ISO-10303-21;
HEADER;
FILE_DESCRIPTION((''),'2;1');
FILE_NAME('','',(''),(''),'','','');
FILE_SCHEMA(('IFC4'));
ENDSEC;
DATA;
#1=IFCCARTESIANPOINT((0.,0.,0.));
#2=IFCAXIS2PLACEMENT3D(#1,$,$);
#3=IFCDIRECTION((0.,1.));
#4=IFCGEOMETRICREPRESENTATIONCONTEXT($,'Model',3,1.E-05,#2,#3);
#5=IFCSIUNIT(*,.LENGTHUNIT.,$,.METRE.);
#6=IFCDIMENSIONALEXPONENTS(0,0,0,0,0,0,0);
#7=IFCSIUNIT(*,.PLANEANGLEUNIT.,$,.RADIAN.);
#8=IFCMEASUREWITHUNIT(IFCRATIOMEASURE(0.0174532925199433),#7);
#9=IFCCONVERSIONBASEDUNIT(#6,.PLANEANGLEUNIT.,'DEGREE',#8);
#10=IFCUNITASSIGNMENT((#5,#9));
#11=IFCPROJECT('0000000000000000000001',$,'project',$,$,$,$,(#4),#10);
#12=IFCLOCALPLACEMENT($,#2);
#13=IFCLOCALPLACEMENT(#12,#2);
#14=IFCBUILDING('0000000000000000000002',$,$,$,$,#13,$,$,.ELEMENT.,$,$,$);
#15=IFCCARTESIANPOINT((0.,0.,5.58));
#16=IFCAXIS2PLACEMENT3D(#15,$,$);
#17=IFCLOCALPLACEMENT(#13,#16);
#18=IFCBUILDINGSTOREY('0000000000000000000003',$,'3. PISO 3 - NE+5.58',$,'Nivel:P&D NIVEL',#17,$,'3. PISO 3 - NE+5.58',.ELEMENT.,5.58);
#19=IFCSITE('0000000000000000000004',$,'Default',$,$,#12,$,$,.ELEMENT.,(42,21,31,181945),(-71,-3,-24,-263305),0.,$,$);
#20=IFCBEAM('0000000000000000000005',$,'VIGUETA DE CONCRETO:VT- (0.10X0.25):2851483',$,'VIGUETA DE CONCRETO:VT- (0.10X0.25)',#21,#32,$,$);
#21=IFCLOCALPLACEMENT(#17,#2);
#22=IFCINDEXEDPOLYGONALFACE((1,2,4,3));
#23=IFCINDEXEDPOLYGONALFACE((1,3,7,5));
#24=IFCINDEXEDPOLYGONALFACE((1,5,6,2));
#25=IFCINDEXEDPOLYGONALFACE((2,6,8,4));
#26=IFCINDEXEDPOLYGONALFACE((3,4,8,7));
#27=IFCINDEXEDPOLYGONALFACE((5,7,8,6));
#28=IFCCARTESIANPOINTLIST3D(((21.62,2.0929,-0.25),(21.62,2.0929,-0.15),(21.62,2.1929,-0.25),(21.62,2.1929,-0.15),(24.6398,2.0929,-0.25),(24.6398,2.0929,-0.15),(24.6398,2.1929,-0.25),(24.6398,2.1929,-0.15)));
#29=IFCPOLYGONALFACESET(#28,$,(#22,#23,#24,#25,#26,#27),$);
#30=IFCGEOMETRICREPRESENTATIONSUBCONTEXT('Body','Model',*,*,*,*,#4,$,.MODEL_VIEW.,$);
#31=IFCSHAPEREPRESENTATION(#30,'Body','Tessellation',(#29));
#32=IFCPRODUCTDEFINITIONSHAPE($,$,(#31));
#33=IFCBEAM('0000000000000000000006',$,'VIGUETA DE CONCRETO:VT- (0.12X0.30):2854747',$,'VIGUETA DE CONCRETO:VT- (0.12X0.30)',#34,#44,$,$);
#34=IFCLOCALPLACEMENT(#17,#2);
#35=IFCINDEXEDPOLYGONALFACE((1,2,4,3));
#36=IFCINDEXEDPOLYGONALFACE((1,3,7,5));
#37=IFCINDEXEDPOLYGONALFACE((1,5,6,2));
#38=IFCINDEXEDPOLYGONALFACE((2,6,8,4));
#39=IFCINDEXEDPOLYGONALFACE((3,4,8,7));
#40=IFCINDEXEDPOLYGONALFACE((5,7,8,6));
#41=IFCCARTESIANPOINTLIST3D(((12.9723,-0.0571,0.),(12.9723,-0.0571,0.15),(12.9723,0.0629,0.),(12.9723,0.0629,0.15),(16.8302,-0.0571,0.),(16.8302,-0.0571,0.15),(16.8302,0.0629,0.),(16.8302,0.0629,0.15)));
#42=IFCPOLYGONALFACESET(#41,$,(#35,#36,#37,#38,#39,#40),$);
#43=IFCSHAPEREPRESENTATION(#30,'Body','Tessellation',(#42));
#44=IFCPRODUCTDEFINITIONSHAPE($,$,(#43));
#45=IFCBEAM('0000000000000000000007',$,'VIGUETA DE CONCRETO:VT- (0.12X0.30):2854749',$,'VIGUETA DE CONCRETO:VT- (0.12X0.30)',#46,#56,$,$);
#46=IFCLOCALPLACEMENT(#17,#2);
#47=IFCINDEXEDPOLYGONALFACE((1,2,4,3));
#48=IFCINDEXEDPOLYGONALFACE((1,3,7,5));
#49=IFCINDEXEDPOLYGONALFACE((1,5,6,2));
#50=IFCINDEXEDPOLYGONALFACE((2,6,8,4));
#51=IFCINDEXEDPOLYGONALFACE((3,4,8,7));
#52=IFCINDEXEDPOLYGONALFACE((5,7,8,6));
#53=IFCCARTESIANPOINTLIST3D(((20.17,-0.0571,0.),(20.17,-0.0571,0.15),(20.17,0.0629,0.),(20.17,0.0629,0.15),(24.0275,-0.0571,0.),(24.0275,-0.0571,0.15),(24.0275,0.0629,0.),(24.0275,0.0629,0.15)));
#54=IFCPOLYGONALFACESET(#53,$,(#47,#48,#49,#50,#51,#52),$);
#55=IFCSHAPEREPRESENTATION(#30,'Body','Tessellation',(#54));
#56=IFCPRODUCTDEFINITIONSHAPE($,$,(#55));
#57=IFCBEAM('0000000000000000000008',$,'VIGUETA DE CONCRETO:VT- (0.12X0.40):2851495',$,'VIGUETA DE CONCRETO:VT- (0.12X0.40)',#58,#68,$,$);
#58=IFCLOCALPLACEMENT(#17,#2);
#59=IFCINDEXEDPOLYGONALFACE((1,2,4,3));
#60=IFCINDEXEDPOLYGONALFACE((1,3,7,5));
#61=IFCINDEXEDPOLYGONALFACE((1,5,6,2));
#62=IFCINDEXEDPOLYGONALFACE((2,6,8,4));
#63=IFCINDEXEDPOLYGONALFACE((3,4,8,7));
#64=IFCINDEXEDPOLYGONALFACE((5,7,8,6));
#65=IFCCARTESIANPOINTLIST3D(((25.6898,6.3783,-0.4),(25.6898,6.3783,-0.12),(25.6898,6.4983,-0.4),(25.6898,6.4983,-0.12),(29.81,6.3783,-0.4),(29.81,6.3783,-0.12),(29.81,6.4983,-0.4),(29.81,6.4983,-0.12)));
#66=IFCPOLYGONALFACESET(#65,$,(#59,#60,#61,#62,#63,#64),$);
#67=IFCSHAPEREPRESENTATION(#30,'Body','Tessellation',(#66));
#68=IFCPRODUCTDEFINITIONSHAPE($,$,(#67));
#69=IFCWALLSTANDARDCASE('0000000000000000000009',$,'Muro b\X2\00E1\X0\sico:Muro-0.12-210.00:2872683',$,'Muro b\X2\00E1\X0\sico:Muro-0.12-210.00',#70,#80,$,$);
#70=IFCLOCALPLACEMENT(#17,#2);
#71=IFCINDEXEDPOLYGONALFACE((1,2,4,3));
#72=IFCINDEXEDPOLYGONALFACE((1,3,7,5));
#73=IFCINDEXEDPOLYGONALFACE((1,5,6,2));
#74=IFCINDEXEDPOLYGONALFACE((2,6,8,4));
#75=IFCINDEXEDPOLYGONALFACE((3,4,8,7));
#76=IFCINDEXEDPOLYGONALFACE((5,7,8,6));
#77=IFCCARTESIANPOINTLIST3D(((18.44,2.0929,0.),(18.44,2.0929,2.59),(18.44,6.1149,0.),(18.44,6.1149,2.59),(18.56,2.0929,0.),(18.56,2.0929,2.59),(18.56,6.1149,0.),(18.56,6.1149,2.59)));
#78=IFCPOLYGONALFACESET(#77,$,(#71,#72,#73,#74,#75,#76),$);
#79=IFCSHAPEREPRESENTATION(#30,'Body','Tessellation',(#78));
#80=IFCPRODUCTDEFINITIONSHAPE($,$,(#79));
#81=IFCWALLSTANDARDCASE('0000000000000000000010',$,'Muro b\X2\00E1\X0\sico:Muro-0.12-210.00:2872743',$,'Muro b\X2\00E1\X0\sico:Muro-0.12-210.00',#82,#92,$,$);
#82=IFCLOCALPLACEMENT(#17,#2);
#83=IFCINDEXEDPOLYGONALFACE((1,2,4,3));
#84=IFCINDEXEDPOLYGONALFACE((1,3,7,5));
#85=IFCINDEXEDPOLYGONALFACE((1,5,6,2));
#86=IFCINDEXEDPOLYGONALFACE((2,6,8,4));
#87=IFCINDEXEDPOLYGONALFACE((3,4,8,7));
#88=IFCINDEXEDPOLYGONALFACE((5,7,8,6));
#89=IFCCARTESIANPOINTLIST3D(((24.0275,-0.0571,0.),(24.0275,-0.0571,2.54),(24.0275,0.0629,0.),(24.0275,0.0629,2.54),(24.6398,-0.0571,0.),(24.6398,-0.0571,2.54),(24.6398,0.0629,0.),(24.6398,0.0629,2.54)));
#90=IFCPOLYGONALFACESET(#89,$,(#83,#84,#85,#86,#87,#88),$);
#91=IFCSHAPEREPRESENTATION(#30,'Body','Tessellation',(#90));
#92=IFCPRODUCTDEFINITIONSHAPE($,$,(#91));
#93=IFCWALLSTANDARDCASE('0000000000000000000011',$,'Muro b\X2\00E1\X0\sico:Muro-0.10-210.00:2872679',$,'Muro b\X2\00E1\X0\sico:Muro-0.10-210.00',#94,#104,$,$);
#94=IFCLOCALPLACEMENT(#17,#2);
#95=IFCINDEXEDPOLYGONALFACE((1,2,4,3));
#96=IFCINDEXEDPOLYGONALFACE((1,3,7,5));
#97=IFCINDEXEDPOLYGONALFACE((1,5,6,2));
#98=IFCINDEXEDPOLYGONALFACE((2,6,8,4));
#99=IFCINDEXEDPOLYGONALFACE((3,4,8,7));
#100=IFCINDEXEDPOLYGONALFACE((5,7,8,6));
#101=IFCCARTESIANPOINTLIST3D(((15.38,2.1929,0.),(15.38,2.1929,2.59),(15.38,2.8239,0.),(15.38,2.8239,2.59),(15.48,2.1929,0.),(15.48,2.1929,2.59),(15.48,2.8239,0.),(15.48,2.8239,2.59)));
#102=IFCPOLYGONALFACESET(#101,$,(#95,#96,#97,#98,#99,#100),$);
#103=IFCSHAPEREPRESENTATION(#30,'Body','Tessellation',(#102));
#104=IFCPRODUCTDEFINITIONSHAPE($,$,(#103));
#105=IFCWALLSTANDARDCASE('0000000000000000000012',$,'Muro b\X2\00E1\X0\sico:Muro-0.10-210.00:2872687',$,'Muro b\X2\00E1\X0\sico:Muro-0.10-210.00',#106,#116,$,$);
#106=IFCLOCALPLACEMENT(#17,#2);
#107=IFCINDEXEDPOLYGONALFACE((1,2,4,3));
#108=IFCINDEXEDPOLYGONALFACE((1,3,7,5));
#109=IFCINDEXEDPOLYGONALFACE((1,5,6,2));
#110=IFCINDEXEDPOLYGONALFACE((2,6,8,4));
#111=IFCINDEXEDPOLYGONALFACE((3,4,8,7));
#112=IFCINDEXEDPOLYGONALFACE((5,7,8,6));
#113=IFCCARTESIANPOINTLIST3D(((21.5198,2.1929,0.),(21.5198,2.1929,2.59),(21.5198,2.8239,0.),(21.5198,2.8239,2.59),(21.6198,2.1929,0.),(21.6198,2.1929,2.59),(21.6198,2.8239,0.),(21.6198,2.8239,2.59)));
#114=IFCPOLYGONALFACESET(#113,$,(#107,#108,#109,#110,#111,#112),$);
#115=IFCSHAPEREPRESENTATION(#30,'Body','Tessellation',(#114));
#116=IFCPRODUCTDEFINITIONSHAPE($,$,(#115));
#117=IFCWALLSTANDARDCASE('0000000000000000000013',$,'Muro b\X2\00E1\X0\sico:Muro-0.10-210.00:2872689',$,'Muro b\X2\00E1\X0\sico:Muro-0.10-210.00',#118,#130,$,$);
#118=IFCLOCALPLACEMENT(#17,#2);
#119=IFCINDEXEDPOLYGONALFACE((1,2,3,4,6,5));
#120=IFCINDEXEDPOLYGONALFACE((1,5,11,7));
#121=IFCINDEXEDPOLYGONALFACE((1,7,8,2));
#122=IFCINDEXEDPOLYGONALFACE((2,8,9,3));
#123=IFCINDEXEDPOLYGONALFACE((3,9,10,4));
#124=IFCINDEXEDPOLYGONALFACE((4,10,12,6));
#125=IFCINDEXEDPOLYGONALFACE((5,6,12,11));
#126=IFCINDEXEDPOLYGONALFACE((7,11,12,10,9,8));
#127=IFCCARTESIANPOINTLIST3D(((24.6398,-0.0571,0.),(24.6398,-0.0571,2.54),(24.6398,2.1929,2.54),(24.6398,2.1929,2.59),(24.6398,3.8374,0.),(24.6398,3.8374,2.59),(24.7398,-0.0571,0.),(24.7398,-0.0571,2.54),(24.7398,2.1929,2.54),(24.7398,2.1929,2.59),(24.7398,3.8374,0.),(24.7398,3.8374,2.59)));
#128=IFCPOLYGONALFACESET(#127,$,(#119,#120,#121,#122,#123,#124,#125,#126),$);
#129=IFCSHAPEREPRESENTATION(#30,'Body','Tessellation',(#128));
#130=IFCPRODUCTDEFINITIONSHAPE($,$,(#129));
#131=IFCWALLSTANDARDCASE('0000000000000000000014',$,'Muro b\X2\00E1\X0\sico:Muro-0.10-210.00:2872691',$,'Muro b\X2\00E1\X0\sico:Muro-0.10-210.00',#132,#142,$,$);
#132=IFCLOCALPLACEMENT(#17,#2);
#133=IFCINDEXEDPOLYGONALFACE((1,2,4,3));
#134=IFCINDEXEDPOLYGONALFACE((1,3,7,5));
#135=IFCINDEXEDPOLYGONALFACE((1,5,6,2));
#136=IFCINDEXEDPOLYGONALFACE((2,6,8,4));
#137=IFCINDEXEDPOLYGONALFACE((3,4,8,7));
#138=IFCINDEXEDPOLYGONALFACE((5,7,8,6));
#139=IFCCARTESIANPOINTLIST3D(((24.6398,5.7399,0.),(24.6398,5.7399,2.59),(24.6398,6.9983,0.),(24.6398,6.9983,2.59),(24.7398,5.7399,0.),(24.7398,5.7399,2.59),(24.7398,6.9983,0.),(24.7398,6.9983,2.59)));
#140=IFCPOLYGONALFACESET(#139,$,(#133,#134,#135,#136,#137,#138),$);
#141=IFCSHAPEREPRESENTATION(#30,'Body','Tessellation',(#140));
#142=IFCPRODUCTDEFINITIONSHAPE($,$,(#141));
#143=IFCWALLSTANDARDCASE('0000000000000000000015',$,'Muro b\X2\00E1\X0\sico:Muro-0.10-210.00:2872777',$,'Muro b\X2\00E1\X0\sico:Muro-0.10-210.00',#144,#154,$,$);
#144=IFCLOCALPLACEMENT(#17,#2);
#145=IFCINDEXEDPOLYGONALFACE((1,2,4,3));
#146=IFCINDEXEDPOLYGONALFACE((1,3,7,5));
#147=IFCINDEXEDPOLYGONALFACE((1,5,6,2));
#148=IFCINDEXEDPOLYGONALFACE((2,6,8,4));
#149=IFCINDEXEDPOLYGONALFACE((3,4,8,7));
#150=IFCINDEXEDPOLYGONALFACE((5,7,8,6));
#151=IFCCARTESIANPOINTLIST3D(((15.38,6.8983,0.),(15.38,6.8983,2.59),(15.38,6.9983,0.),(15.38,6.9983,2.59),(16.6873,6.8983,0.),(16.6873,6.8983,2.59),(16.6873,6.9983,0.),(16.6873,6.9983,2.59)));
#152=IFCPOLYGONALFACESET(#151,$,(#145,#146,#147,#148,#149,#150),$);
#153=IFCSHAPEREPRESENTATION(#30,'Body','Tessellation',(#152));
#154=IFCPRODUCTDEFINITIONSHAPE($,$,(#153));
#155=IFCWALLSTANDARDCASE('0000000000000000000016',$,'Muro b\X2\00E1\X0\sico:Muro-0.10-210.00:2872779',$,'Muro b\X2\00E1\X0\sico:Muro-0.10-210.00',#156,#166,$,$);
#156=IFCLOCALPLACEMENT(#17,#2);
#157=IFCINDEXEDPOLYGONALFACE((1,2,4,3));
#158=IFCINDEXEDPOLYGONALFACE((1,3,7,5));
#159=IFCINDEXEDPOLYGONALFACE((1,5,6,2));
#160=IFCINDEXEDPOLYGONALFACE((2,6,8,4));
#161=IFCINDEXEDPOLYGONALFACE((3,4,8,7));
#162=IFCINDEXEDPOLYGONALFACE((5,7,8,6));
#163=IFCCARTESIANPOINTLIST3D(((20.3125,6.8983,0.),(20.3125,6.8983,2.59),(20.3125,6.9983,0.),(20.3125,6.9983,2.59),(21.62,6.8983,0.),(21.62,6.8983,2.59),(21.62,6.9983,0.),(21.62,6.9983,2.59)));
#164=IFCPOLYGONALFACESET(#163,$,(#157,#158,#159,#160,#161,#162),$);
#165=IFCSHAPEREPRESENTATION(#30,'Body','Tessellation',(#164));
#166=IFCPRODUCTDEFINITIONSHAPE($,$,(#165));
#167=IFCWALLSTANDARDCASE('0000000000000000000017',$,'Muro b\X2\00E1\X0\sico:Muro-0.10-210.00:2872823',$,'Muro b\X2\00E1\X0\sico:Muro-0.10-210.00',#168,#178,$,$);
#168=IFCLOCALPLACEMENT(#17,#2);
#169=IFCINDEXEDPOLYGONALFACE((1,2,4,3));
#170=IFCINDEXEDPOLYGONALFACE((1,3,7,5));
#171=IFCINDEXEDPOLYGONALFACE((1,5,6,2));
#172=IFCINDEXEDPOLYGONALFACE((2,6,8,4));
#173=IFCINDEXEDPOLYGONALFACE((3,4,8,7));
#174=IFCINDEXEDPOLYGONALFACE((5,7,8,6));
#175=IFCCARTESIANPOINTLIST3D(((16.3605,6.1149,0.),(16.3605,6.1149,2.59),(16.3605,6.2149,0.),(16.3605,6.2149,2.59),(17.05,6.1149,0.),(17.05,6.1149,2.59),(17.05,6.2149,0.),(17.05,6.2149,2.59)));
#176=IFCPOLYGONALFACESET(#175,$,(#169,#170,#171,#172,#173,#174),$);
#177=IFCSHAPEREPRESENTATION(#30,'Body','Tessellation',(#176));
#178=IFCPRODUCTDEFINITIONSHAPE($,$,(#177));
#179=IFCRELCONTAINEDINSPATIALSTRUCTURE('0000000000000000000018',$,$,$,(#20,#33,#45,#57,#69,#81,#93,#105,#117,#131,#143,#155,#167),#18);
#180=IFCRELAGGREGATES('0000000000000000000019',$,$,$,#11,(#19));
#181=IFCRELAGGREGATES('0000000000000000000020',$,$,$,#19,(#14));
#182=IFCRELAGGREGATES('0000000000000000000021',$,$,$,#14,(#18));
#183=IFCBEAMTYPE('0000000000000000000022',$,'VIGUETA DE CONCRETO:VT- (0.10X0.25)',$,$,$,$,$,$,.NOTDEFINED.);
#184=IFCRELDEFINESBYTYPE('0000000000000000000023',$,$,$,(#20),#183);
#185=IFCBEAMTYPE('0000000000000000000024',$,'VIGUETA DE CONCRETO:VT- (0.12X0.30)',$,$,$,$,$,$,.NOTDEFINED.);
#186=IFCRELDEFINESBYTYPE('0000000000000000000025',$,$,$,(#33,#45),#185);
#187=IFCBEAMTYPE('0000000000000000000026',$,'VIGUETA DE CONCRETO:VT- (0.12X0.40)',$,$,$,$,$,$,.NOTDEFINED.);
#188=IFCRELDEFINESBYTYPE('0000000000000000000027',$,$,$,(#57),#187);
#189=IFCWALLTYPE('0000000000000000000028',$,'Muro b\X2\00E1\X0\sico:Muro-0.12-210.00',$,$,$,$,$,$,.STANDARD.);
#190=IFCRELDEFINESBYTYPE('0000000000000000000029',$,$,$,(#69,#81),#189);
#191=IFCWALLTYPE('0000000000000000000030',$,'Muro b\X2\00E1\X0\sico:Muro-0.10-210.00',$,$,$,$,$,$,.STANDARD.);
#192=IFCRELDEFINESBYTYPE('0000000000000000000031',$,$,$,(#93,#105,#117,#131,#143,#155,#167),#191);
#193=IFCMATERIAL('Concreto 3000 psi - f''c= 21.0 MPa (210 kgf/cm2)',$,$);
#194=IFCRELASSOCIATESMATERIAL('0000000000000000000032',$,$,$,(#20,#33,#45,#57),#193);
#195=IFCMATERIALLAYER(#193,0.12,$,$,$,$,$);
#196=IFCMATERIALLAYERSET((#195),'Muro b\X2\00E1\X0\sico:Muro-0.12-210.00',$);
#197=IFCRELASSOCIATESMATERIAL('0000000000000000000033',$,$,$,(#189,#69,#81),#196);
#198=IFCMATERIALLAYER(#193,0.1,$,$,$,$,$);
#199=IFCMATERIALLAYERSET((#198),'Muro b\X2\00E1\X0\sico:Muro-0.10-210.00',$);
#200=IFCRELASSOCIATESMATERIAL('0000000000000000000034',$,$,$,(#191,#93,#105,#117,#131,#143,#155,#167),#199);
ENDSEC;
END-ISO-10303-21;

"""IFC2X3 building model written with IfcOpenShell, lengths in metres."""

from ifc_helpers import new_model, entity, si_unit, converted_unit, direction, frame, frame_2d, origin, origin_2d_with_axis, place, context, subcontext, project, spatial, polyline, rectangle, extrude, clip, bounded_halfspace, material, layer, layer_set, layer_usage, type_object, element, save


model = new_model("IFC2X3")

# Units and contexts
model_context = context("Model", 3, precision=1e-05, world=origin(), true_north=direction((0.0, 1.0)))
body_context = subcontext(model_context, "Body", "Model", "MODEL_VIEW")
ifc_project = project(units=[si_unit("LENGTHUNIT", "METRE"), converted_unit("PLANEANGLEUNIT", "DEGREE", entity("IfcRatioMeasure", 0.0174532925199433), si_unit("PLANEANGLEUNIT", "RADIAN"), dimensions=[0, 0, 0, 0, 0, 0, 0])], contexts=[model_context])

# Site, building, storey
site_placement = place(None, origin())
site = spatial("IfcSite", under=ifc_project, at=site_placement, Name="Default", CompositionType="ELEMENT", RefLatitude=(42, 21, 31, 181945), RefLongitude=(-71, -3, -24, -263305), RefElevation=0.0)
building_placement = place(site_placement, origin())
building = spatial("IfcBuilding", under=site, at=building_placement, CompositionType="ELEMENT")
storey_placement = place(building_placement, frame((0.0, 0.0, 5.58)))
storey = spatial("IfcBuildingStorey", under=building, at=storey_placement, Name="3. PISO 3 - NE+5.58", ObjectType="Nivel:P&D NIVEL", LongName="3. PISO 3 - NE+5.58", CompositionType="ELEMENT", Elevation=5.58)

# Beams
ifc_material = material(Name="Concreto 3000 psi - f'c= 21.0 MPa (210 kgf/cm2)")
beam_type_1 = type_object("IfcBeamType", Name="VIGUETA DE CONCRETO:VT- (0.10X0.25)", PredefinedType="NOTDEFINED")
beam_1_placement = place(storey_placement, frame((24.6898, 2.1429, 0.0), z_axis=(0.0, 0.0, 1.0), x_axis=(-1.0, 0.0, 0.0)))
element("IfcBeam", 1, at=beam_1_placement, inside=storey, type_object=beam_type_1, material=ifc_material, Name="VIGUETA DE CONCRETO:VT- (0.10X0.25):2851483", ObjectType="VIGUETA DE CONCRETO:VT- (0.10X0.25)", context=body_context, shape_type="SweptSolid", body=[
    extrude(rectangle(XDim=0.1, YDim=0.1, at=origin_2d_with_axis()), frame((0.05, 0.0, -0.2), z_axis=(1.0, 0.0, 0.0), x_axis=(0.0, 0.0, -1.0)), (0.0, 0.0, 1.0), 3.0198),
])
beam_type_2 = type_object("IfcBeamType", Name="VIGUETA DE CONCRETO:VT- (0.12X0.30)", PredefinedType="NOTDEFINED")
beam_2_placement = place(storey_placement, frame((16.9052, 0.0029, 0.0), z_axis=(0.0, 0.0, 1.0), x_axis=(-1.0, 0.0, 0.0)))
element("IfcBeam", 2, at=beam_2_placement, inside=storey, type_object=beam_type_2, material=ifc_material, Name="VIGUETA DE CONCRETO:VT- (0.12X0.30):2854747", ObjectType="VIGUETA DE CONCRETO:VT- (0.12X0.30)", context=body_context, shape_type="SweptSolid", body=[
    extrude(rectangle(XDim=0.15, YDim=0.12, at=frame_2d((0.0, 0.0), x_axis=(1.0, 0.0))), frame((0.075, 0.0, 0.075), z_axis=(1.0, 0.0, 0.0), x_axis=(0.0, 0.0, -1.0)), (0.0, 0.0, 1.0), 3.8579),
])
beam_3_placement = place(storey_placement, frame((20.095, 0.0029, 0.0)))
element("IfcBeam", 3, at=beam_3_placement, inside=storey, type_object=beam_type_2, material=ifc_material, Name="VIGUETA DE CONCRETO:VT- (0.12X0.30):2854749", ObjectType="VIGUETA DE CONCRETO:VT- (0.12X0.30)", context=body_context, shape_type="SweptSolid", body=[
    extrude(rectangle(XDim=0.15, YDim=0.12, at=frame_2d((0.0, 0.0), x_axis=(1.0, 0.0))), frame((0.075, 0.0, 0.075), z_axis=(1.0, 0.0, 0.0), x_axis=(0.0, 0.0, -1.0)), (0.0, 0.0, 1.0), 3.8575),
])
beam_type_3 = type_object("IfcBeamType", Name="VIGUETA DE CONCRETO:VT- (0.12X0.40)", PredefinedType="NOTDEFINED")
beam_4_placement = place(storey_placement, frame((24.6898, 6.4383, 0.0)))
element("IfcBeam", 4, at=beam_4_placement, inside=storey, type_object=beam_type_3, material=ifc_material, Name="VIGUETA DE CONCRETO:VT- (0.12X0.40):2851495", ObjectType="VIGUETA DE CONCRETO:VT- (0.12X0.40)", context=body_context, shape_type="SweptSolid", body=[
    extrude(rectangle(XDim=0.28, YDim=0.12, at=frame_2d((0.0, 0.0), x_axis=(1.0, 0.0))), frame((1.0, 0.0, -0.26), z_axis=(1.0, 0.0, 0.0), x_axis=(0.0, 0.0, -1.0)), (0.0, 0.0, 1.0), 4.1202),
])

# Walls
ifc_layer_1 = layer(ifc_material, 0.12)
ifc_layer_set_1 = layer_set([ifc_layer_1], Name="Muro básico:Muro-0.12-210.00")
ifc_layer_usage_1 = layer_usage(ifc_layer_set_1, "AXIS2", "POSITIVE", -0.06)
wall_type_1 = type_object("IfcWallType", Name="Muro básico:Muro-0.12-210.00", PredefinedType="STANDARD", material=ifc_layer_set_1)
wall_1_placement = place(storey_placement, frame((18.5, 2.0929, 0.0), z_axis=(0.0, 0.0, 1.0), x_axis=(0.0, 1.0, 0.0)))
element("IfcWallStandardCase", 5, at=wall_1_placement, inside=storey, type_object=wall_type_1, material=ifc_layer_usage_1, Name="Muro básico:Muro-0.12-210.00:2872683", ObjectType="Muro básico:Muro-0.12-210.00", context=body_context, shape_type="SweptSolid", body=[
    extrude(rectangle(XDim=4.022, YDim=0.12, at=frame_2d((2.011, 0.0), x_axis=(-1.0, 0.0))), origin(), (0.0, 0.0, 1.0), 2.59),
])
wall_2_placement = place(storey_placement, frame((24.0275, 0.0029, 0.0)))
element("IfcWallStandardCase", 6, at=wall_2_placement, inside=storey, type_object=wall_type_1, material=ifc_layer_usage_1, Name="Muro básico:Muro-0.12-210.00:2872743", ObjectType="Muro básico:Muro-0.12-210.00", context=body_context, shape_type="SweptSolid", body=[
    extrude(rectangle(XDim=0.6123, YDim=0.12, at=frame_2d((0.3061, 0.0), x_axis=(-1.0, 0.0))), origin(), (0.0, 0.0, 1.0), 2.54),
])
ifc_layer_2 = layer(ifc_material, 0.1)
ifc_layer_set_2 = layer_set([ifc_layer_2], Name="Muro básico:Muro-0.10-210.00")
ifc_layer_usage_2 = layer_usage(ifc_layer_set_2, "AXIS2", "POSITIVE", -0.05)
wall_type_2 = type_object("IfcWallType", Name="Muro básico:Muro-0.10-210.00", PredefinedType="STANDARD", material=ifc_layer_set_2)
wall_3_placement = place(storey_placement, frame((15.43, 2.1929, 0.0), z_axis=(0.0, 0.0, 1.0), x_axis=(0.0, 1.0, 0.0)))
element("IfcWallStandardCase", 7, at=wall_3_placement, inside=storey, type_object=wall_type_2, material=ifc_layer_usage_2, Name="Muro básico:Muro-0.10-210.00:2872679", ObjectType="Muro básico:Muro-0.10-210.00", context=body_context, shape_type="SweptSolid", body=[
    extrude(rectangle(XDim=0.631, YDim=0.1, at=frame_2d((0.3155, 0.0), x_axis=(-1.0, 0.0))), origin(), (0.0, 0.0, 1.0), 2.59),
])
wall_4_placement = place(storey_placement, frame((21.5698, 2.1929, 0.0), z_axis=(0.0, 0.0, 1.0), x_axis=(0.0, 1.0, 0.0)))
element("IfcWallStandardCase", 8, at=wall_4_placement, inside=storey, type_object=wall_type_2, material=ifc_layer_usage_2, Name="Muro básico:Muro-0.10-210.00:2872687", ObjectType="Muro básico:Muro-0.10-210.00", context=body_context, shape_type="SweptSolid", body=[
    extrude(rectangle(XDim=0.631, YDim=0.1, at=frame_2d((0.3155, 0.0), x_axis=(-1.0, 0.0))), origin(), (0.0, 0.0, 1.0), 2.59),
])
wall_5_placement = place(storey_placement, frame((24.6898, -0.0571, 0.0), z_axis=(0.0, 0.0, 1.0), x_axis=(0.0, 1.0, 0.0)))
element("IfcWallStandardCase", 9, at=wall_5_placement, inside=storey, type_object=wall_type_2, material=ifc_layer_usage_2, Name="Muro básico:Muro-0.10-210.00:2872689", ObjectType="Muro básico:Muro-0.10-210.00", context=body_context, shape_type="Clipping", body=[
    clip(clip(extrude(rectangle(XDim=3.8945, YDim=0.1, at=frame_2d((1.9473, 0.0), x_axis=(-1.0, 0.0))), origin(), (0.0, 0.0, 1.0), 2.59), bounded_halfspace(frame((2.25, -0.05, 2.54), z_axis=(0.0, 0.0, -1.0), x_axis=(0.0, -1.0, 0.0)), True, frame((2.25, -0.05, 2.54), z_axis=(0.0, 0.0, -1.0), x_axis=(0.0, -1.0, 0.0)), polyline([(0.0, 0.0), (0.0, 2.25), (-0.1, 2.25), (-0.1, 2.13), (-0.1, 0.0), (0.0, 0.0)]))), bounded_halfspace(frame((2.25, 0.05, 2.54), z_axis=(1.0, 0.0, 0.0), x_axis=(0.0, 0.0, 1.0)), True, frame((2.25, 0.05, 2.54), z_axis=(1.0, 0.0, 0.0), x_axis=(0.0, 0.0, 1.0)), polyline([(0.0, 0.0), (0.05, 0.0), (0.05, 0.1), (0.0, 0.1), (0.0, 0.0)]))),
])
wall_6_placement = place(storey_placement, frame((24.6898, 5.7399, 0.0), z_axis=(0.0, 0.0, 1.0), x_axis=(0.0, 1.0, 0.0)))
element("IfcWallStandardCase", 10, at=wall_6_placement, inside=storey, type_object=wall_type_2, material=ifc_layer_usage_2, Name="Muro básico:Muro-0.10-210.00:2872691", ObjectType="Muro básico:Muro-0.10-210.00", context=body_context, shape_type="SweptSolid", body=[
    extrude(rectangle(XDim=1.2584, YDim=0.1, at=frame_2d((0.6292, 0.0), x_axis=(-1.0, 0.0))), origin(), (0.0, 0.0, 1.0), 2.59),
])
wall_7_placement = place(storey_placement, frame((15.38, 6.9483, 0.0)))
element("IfcWallStandardCase", 11, at=wall_7_placement, inside=storey, type_object=wall_type_2, material=ifc_layer_usage_2, Name="Muro básico:Muro-0.10-210.00:2872777", ObjectType="Muro básico:Muro-0.10-210.00", context=body_context, shape_type="SweptSolid", body=[
    extrude(rectangle(XDim=1.3073, YDim=0.1, at=frame_2d((0.6536, 0.0), x_axis=(-1.0, 0.0))), origin(), (0.0, 0.0, 1.0), 2.59),
])
wall_8_placement = place(storey_placement, frame((20.3125, 6.9483, 0.0)))
element("IfcWallStandardCase", 12, at=wall_8_placement, inside=storey, type_object=wall_type_2, material=ifc_layer_usage_2, Name="Muro básico:Muro-0.10-210.00:2872779", ObjectType="Muro básico:Muro-0.10-210.00", context=body_context, shape_type="SweptSolid", body=[
    extrude(rectangle(XDim=1.3075, YDim=0.1, at=frame_2d((0.6538, 0.0), x_axis=(-1.0, 0.0))), origin(), (0.0, 0.0, 1.0), 2.59),
])
wall_9_placement = place(storey_placement, frame((16.3605, 6.1649, 0.0)))
element("IfcWallStandardCase", 13, at=wall_9_placement, inside=storey, type_object=wall_type_2, material=ifc_layer_usage_2, Name="Muro básico:Muro-0.10-210.00:2872823", ObjectType="Muro básico:Muro-0.10-210.00", context=body_context, shape_type="SweptSolid", body=[
    extrude(rectangle(XDim=0.6895, YDim=0.1, at=frame_2d((0.3447, 0.0), x_axis=(-1.0, 0.0))), origin(), (0.0, 0.0, 1.0), 2.59),
])

save(model, "model.ifc")
